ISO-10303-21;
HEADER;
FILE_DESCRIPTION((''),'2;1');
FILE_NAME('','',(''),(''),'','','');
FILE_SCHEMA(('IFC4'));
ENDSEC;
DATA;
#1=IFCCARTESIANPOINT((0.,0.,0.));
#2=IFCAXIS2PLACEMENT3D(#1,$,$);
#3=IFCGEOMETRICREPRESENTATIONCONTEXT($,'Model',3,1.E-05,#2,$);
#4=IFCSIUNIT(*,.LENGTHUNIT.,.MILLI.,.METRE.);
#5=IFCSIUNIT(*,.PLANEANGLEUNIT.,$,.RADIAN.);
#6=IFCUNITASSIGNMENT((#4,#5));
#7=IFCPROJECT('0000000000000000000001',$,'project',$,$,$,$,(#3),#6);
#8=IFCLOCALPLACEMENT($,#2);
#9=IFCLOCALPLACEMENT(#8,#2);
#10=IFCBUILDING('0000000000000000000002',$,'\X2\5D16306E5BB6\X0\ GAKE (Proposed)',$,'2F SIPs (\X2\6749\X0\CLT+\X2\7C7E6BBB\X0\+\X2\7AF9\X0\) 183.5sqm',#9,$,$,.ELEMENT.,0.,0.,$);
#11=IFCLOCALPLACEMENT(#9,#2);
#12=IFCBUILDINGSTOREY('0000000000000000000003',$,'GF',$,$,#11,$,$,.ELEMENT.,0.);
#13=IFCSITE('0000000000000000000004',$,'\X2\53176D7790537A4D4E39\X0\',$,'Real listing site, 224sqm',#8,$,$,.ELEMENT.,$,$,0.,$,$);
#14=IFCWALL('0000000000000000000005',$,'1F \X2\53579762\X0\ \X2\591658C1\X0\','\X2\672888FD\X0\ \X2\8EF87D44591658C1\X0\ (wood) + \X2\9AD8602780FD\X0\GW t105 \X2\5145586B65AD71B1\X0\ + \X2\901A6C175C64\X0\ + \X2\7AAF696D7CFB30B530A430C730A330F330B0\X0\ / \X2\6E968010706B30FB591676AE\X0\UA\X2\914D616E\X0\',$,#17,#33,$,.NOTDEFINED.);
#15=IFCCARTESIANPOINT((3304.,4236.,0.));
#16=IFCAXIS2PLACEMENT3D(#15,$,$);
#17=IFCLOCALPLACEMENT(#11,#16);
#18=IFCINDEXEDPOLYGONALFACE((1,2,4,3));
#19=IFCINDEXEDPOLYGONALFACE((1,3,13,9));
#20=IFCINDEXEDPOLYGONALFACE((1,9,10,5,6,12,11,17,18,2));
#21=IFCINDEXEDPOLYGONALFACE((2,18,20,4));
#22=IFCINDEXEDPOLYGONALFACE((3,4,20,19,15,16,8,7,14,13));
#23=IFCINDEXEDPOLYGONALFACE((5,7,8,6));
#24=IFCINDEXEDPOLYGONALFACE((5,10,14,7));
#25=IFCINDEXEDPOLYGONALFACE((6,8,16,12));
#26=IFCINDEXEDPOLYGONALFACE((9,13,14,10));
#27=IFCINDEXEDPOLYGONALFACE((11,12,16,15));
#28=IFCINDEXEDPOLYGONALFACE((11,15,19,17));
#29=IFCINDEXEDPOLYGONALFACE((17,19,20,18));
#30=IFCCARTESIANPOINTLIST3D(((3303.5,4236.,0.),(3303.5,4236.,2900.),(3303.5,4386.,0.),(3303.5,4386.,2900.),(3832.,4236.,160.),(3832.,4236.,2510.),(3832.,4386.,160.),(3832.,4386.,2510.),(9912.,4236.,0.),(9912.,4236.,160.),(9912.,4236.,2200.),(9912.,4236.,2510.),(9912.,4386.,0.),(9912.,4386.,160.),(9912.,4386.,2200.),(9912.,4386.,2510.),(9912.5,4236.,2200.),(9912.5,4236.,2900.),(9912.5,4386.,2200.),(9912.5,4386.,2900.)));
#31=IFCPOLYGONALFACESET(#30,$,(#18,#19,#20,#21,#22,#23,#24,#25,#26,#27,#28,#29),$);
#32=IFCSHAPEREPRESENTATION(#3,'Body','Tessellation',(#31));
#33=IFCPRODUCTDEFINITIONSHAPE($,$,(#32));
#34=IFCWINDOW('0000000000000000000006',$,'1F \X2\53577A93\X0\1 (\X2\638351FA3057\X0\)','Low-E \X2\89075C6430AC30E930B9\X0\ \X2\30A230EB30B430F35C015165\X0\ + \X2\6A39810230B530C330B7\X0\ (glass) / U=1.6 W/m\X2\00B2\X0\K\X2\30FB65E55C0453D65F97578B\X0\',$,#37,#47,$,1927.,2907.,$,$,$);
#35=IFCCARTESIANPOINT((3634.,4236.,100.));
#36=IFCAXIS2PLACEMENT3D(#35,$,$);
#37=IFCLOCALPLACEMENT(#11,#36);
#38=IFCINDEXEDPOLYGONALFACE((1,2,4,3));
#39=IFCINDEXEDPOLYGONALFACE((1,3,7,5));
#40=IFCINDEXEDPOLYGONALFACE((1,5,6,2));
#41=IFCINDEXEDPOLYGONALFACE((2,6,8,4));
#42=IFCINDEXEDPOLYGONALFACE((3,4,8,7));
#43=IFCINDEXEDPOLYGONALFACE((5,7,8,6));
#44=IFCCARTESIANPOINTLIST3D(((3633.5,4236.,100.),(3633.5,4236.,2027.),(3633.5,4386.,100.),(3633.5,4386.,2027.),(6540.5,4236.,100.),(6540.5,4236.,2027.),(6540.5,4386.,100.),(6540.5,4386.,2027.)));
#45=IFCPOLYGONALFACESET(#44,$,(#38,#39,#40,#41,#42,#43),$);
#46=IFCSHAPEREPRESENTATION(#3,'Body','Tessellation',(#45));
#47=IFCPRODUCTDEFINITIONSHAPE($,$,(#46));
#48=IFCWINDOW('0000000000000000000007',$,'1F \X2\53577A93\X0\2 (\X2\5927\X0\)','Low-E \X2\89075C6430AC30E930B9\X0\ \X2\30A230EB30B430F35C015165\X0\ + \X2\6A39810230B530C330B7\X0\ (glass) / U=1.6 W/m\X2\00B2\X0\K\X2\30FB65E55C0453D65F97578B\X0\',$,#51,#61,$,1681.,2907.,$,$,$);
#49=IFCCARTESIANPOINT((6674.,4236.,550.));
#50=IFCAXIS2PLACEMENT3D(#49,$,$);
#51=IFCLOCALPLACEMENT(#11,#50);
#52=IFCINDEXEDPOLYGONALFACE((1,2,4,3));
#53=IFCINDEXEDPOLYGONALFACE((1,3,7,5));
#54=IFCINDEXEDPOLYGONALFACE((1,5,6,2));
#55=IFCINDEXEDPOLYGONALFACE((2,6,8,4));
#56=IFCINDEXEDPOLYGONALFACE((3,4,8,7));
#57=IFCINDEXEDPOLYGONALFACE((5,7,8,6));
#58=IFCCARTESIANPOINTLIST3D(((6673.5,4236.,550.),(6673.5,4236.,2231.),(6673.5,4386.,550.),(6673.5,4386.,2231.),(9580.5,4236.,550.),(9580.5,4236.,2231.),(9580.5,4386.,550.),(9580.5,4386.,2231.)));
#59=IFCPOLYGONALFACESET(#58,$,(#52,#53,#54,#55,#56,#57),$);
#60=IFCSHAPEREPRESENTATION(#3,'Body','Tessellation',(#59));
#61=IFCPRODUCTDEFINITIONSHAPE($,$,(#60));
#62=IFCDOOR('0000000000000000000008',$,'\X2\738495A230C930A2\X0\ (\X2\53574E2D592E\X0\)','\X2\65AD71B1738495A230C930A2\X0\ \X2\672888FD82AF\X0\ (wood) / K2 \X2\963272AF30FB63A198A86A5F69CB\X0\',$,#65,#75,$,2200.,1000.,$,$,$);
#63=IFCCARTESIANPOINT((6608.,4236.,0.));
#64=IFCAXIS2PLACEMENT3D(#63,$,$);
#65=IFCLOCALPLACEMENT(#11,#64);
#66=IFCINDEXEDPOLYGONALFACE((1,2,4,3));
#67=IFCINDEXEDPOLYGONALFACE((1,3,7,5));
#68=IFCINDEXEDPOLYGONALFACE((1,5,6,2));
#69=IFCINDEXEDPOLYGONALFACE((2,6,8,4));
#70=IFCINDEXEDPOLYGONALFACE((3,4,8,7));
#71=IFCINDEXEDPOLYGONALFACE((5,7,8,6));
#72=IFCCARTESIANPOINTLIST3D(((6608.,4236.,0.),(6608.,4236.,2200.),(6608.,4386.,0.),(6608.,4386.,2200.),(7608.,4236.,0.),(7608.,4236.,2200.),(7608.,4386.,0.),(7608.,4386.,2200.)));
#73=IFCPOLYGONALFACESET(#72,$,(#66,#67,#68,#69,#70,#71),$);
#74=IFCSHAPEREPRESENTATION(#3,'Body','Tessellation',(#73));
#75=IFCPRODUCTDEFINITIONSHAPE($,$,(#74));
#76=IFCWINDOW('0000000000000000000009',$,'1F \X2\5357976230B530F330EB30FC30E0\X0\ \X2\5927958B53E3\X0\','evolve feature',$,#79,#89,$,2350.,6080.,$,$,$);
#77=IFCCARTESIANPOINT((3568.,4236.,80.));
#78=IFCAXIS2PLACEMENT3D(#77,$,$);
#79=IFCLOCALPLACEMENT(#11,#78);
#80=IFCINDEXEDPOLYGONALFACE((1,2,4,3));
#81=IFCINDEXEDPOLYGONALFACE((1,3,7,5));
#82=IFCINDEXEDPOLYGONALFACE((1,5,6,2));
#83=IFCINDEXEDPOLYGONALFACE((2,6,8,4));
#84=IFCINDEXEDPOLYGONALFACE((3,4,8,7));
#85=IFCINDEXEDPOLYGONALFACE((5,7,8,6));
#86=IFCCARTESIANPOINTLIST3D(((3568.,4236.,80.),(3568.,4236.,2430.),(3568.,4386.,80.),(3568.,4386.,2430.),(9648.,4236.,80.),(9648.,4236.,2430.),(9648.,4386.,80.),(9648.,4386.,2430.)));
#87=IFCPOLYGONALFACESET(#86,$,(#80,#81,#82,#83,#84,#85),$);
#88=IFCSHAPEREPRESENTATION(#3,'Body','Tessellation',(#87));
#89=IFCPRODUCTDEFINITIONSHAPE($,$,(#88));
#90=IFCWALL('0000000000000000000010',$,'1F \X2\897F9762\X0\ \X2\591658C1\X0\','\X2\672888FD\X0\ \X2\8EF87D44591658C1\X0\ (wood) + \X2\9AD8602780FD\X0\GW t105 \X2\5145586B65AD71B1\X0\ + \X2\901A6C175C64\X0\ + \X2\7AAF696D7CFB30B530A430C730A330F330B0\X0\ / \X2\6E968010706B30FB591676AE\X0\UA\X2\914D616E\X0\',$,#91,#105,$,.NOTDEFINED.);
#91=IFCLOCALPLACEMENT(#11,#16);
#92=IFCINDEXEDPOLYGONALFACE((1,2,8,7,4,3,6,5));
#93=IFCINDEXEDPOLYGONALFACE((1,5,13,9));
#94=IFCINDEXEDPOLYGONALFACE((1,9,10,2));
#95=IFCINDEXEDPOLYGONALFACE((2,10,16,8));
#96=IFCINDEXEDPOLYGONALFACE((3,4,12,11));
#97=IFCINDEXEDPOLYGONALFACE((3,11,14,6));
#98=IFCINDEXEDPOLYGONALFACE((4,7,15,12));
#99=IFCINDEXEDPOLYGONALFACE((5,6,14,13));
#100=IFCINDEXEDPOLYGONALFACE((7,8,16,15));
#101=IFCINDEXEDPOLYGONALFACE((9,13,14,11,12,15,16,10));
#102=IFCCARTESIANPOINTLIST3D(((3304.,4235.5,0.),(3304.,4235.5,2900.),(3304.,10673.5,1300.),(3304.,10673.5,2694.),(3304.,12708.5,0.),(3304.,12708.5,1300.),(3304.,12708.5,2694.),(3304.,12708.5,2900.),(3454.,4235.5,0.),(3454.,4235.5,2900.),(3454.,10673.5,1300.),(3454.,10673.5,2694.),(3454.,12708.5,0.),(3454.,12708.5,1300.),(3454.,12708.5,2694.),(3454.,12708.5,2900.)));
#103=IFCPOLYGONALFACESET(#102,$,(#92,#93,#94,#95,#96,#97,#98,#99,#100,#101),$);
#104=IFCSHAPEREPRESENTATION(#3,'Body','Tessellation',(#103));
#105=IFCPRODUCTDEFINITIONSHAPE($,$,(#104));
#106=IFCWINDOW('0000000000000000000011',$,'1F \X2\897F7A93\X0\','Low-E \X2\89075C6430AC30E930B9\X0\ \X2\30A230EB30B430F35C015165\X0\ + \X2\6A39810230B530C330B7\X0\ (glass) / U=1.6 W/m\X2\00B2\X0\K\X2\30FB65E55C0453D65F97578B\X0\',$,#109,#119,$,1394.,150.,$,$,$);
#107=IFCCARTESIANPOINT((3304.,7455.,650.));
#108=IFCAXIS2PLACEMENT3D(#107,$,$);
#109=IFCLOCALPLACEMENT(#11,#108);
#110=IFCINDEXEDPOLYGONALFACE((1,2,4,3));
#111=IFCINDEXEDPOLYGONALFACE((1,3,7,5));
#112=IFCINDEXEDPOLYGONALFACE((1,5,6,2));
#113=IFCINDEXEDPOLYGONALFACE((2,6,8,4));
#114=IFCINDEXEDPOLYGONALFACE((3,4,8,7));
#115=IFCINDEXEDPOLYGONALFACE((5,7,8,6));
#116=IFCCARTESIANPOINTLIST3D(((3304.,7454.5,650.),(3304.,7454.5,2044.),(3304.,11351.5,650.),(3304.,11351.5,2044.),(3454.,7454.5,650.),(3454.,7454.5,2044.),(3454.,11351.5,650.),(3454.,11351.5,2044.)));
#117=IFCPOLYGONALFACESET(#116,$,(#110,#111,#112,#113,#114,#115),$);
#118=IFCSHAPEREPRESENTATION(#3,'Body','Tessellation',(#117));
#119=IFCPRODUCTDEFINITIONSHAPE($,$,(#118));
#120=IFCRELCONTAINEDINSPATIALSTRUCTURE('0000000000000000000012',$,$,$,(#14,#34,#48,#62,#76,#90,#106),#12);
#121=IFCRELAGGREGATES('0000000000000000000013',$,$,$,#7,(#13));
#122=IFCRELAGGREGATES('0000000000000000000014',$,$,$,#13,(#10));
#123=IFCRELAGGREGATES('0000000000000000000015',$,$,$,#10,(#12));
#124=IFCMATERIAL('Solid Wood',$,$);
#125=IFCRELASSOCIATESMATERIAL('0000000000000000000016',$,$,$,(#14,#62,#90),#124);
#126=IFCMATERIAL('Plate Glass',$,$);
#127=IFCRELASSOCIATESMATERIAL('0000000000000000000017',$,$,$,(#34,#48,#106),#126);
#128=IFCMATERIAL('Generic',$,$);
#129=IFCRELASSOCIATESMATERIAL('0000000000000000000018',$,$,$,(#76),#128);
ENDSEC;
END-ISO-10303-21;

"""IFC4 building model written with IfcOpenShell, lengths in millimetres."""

from ifc_helpers import new_model, si_unit, frame, frame_2d, origin, place, context, project, spatial, rectangle, extrude, material, element, fill, save


model = new_model("IFC4")

# Units and contexts
model_context = context("Model", 3, precision=1e-05, world=origin())
ifc_project = project(units=[si_unit("LENGTHUNIT", "METRE", prefix="MILLI"), si_unit("PLANEANGLEUNIT", "RADIAN")], contexts=[model_context])

# Site, building, storey
site_placement = place(None, origin())
site = spatial("IfcSite", under=ifc_project, at=site_placement, Name="北海道積丹", ObjectType="Real listing site, 224sqm", CompositionType="ELEMENT", RefElevation=0.0)
building_placement = place(site_placement, origin())
building = spatial("IfcBuilding", under=site, at=building_placement, Name="崖の家 GAKE (Proposed)", ObjectType="2F SIPs (杉CLT+籾殻+竹) 183.5sqm", CompositionType="ELEMENT", ElevationOfRefHeight=0.0, ElevationOfTerrain=0.0)
storey_placement = place(building_placement, origin())
storey = spatial("IfcBuildingStorey", under=building, at=storey_placement, Name="GF", CompositionType="ELEMENT", Elevation=0.0)

# Shared definitions
ifc_material_1 = material(Name="Solid Wood")
ifc_material_2 = material(Name="Generic")

# Wall, openings, windows, door
wall_1_placement = place(storey_placement, frame((3304.0, 4236.0, 0.0)))
wall_1 = element("IfcWall", 1, at=wall_1_placement, inside=storey, material=ifc_material_1, Name="1F 南面 外壁", Description="木製 軸組外壁 (wood) + 高性能GW t105 充填断熱 + 通気層 + 窯業系サイディング / 準耐火・外皮UA配慮", PredefinedType="NOTDEFINED", context=model_context, shape_type="SweptSolid", body=[
    extrude(rectangle(XDim=6609.0, YDim=150.0, at=frame_2d((3304.0, 75.0))), frame((3304.0, 4236.0, 0.0)), (0.0, 0.0, 1.0), 2900.0),
])
opening_1_placement = place(storey_placement, frame((3634.0, 4236.0, 100.0)))
opening_1 = element("IfcOpeningElement", 2, at=opening_1_placement, cuts=wall_1, PredefinedType="NOTDEFINED", context=model_context, shape_type="SweptSolid", body=[
    extrude(rectangle(XDim=2907.0, YDim=150.0, at=frame_2d((1453.0, 75.0))), frame((3634.0, 4236.0, 100.0)), (0.0, 0.0, 1.0), 1927.0),
])
opening_2_placement = place(storey_placement, frame((6674.0, 4236.0, 550.0)))
opening_2 = element("IfcOpeningElement", 3, at=opening_2_placement, cuts=wall_1, PredefinedType="NOTDEFINED", context=model_context, shape_type="SweptSolid", body=[
    extrude(rectangle(XDim=2907.0, YDim=150.0, at=frame_2d((1453.0, 75.0))), frame((6674.0, 4236.0, 550.0)), (0.0, 0.0, 1.0), 1681.0),
])
opening_3_placement = place(storey_placement, frame((6608.0, 4236.0, 0.0)))
opening_3 = element("IfcOpeningElement", 4, at=opening_3_placement, cuts=wall_1, PredefinedType="NOTDEFINED", context=model_context, shape_type="SweptSolid", body=[
    extrude(rectangle(XDim=1000.0, YDim=150.0, at=frame_2d((500.0, 75.0))), frame((6608.0, 4236.0, 0.0)), (0.0, 0.0, 1.0), 2200.0),
])
opening_4_placement = place(storey_placement, frame((3568.0, 4236.0, 80.0)))
opening_4 = element("IfcOpeningElement", 5, at=opening_4_placement, cuts=wall_1, PredefinedType="NOTDEFINED", context=model_context, shape_type="SweptSolid", body=[
    extrude(rectangle(XDim=6080.0, YDim=150.0, at=frame_2d((3040.0, 75.0))), frame((3568.0, 4236.0, 80.0)), (0.0, 0.0, 1.0), 2350.0),
])
ifc_material_3 = material(Name="Plate Glass")
window_1_placement = place(storey_placement, frame((3634.0, 4236.0, 100.0)))
window_1 = element("IfcWindow", 6, at=window_1_placement, inside=storey, material=ifc_material_3, Name="1F 南窓1 (掃出し)", Description="Low-E 複層ガラス アルゴン封入 + 樹脂サッシ (glass) / U=1.6 W/m²K・日射取得型", OverallHeight=1927.0, OverallWidth=2907.0, context=model_context, shape_type="SweptSolid", body=[
    extrude(rectangle(XDim=2907.0, YDim=150.0, at=frame_2d((1453.0, 75.0))), frame((3634.0, 4236.0, 100.0)), (0.0, 0.0, 1.0), 1927.0),
])
fill(opening_1, window_1)
window_2_placement = place(storey_placement, frame((6674.0, 4236.0, 550.0)))
window_2 = element("IfcWindow", 7, at=window_2_placement, inside=storey, material=ifc_material_3, Name="1F 南窓2 (大)", Description="Low-E 複層ガラス アルゴン封入 + 樹脂サッシ (glass) / U=1.6 W/m²K・日射取得型", OverallHeight=1681.0, OverallWidth=2907.0, context=model_context, shape_type="SweptSolid", body=[
    extrude(rectangle(XDim=2907.0, YDim=150.0, at=frame_2d((1453.0, 75.0))), frame((6674.0, 4236.0, 550.0)), (0.0, 0.0, 1.0), 1681.0),
])
fill(opening_2, window_2)
door_placement = place(storey_placement, frame((6608.0, 4236.0, 0.0)))
door = element("IfcDoor", 8, at=door_placement, inside=storey, material=ifc_material_1, Name="玄関ドア (南中央)", Description="断熱玄関ドア 木製芯 (wood) / K2 防犯・採風機構", OverallHeight=2200.0, OverallWidth=1000.0, context=model_context, shape_type="SweptSolid", body=[
    extrude(rectangle(XDim=1000.0, YDim=150.0, at=frame_2d((500.0, 75.0))), frame((6608.0, 4236.0, 0.0)), (0.0, 0.0, 1.0), 2200.0),
])
fill(opening_3, door)
window_3_placement = place(storey_placement, frame((3568.0, 4236.0, 80.0)))
window_3 = element("IfcWindow", 9, at=window_3_placement, inside=storey, material=ifc_material_2, Name="1F 南面サンルーム 大開口", Description="evolve feature", OverallHeight=2350.0, OverallWidth=6080.0, context=model_context, shape_type="SweptSolid", body=[
    extrude(rectangle(XDim=6080.0, YDim=150.0, at=frame_2d((3040.0, 75.0))), frame((3568.0, 4236.0, 80.0)), (0.0, 0.0, 1.0), 2350.0),
])
fill(opening_4, window_3)

# Wall, opening, window
wall_2_placement = place(storey_placement, frame((3304.0, 4236.0, 0.0)))
wall_2 = element("IfcWall", 10, at=wall_2_placement, inside=storey, material=ifc_material_1, Name="1F 西面 外壁", Description="木製 軸組外壁 (wood) + 高性能GW t105 充填断熱 + 通気層 + 窯業系サイディング / 準耐火・外皮UA配慮", PredefinedType="NOTDEFINED", context=model_context, shape_type="SweptSolid", body=[
    extrude(rectangle(XDim=150.0, YDim=8473.0, at=frame_2d((75.0, 4236.0))), frame((3304.0, 4236.0, 0.0)), (0.0, 0.0, 1.0), 2900.0),
])
opening_5_placement = place(storey_placement, frame((3304.0, 7455.0, 650.0)))
opening_5 = element("IfcOpeningElement", 11, at=opening_5_placement, cuts=wall_2, PredefinedType="NOTDEFINED", context=model_context, shape_type="SweptSolid", body=[
    extrude(rectangle(XDim=150.0, YDim=3897.0, at=frame_2d((75.0, 1948.0))), frame((3304.0, 7455.0, 650.0)), (0.0, 0.0, 1.0), 1394.0),
])
window_4_placement = place(storey_placement, frame((3304.0, 7455.0, 650.0)))
window_4 = element("IfcWindow", 12, at=window_4_placement, inside=storey, material=ifc_material_3, Name="1F 西窓", Description="Low-E 複層ガラス アルゴン封入 + 樹脂サッシ (glass) / U=1.6 W/m²K・日射取得型", OverallHeight=1394.0, OverallWidth=150.0, context=model_context, shape_type="SweptSolid", body=[
    extrude(rectangle(XDim=150.0, YDim=3897.0, at=frame_2d((75.0, 1948.0))), frame((3304.0, 7455.0, 650.0)), (0.0, 0.0, 1.0), 1394.0),
])
fill(opening_5, window_4)

save(model, "model.ifc")
